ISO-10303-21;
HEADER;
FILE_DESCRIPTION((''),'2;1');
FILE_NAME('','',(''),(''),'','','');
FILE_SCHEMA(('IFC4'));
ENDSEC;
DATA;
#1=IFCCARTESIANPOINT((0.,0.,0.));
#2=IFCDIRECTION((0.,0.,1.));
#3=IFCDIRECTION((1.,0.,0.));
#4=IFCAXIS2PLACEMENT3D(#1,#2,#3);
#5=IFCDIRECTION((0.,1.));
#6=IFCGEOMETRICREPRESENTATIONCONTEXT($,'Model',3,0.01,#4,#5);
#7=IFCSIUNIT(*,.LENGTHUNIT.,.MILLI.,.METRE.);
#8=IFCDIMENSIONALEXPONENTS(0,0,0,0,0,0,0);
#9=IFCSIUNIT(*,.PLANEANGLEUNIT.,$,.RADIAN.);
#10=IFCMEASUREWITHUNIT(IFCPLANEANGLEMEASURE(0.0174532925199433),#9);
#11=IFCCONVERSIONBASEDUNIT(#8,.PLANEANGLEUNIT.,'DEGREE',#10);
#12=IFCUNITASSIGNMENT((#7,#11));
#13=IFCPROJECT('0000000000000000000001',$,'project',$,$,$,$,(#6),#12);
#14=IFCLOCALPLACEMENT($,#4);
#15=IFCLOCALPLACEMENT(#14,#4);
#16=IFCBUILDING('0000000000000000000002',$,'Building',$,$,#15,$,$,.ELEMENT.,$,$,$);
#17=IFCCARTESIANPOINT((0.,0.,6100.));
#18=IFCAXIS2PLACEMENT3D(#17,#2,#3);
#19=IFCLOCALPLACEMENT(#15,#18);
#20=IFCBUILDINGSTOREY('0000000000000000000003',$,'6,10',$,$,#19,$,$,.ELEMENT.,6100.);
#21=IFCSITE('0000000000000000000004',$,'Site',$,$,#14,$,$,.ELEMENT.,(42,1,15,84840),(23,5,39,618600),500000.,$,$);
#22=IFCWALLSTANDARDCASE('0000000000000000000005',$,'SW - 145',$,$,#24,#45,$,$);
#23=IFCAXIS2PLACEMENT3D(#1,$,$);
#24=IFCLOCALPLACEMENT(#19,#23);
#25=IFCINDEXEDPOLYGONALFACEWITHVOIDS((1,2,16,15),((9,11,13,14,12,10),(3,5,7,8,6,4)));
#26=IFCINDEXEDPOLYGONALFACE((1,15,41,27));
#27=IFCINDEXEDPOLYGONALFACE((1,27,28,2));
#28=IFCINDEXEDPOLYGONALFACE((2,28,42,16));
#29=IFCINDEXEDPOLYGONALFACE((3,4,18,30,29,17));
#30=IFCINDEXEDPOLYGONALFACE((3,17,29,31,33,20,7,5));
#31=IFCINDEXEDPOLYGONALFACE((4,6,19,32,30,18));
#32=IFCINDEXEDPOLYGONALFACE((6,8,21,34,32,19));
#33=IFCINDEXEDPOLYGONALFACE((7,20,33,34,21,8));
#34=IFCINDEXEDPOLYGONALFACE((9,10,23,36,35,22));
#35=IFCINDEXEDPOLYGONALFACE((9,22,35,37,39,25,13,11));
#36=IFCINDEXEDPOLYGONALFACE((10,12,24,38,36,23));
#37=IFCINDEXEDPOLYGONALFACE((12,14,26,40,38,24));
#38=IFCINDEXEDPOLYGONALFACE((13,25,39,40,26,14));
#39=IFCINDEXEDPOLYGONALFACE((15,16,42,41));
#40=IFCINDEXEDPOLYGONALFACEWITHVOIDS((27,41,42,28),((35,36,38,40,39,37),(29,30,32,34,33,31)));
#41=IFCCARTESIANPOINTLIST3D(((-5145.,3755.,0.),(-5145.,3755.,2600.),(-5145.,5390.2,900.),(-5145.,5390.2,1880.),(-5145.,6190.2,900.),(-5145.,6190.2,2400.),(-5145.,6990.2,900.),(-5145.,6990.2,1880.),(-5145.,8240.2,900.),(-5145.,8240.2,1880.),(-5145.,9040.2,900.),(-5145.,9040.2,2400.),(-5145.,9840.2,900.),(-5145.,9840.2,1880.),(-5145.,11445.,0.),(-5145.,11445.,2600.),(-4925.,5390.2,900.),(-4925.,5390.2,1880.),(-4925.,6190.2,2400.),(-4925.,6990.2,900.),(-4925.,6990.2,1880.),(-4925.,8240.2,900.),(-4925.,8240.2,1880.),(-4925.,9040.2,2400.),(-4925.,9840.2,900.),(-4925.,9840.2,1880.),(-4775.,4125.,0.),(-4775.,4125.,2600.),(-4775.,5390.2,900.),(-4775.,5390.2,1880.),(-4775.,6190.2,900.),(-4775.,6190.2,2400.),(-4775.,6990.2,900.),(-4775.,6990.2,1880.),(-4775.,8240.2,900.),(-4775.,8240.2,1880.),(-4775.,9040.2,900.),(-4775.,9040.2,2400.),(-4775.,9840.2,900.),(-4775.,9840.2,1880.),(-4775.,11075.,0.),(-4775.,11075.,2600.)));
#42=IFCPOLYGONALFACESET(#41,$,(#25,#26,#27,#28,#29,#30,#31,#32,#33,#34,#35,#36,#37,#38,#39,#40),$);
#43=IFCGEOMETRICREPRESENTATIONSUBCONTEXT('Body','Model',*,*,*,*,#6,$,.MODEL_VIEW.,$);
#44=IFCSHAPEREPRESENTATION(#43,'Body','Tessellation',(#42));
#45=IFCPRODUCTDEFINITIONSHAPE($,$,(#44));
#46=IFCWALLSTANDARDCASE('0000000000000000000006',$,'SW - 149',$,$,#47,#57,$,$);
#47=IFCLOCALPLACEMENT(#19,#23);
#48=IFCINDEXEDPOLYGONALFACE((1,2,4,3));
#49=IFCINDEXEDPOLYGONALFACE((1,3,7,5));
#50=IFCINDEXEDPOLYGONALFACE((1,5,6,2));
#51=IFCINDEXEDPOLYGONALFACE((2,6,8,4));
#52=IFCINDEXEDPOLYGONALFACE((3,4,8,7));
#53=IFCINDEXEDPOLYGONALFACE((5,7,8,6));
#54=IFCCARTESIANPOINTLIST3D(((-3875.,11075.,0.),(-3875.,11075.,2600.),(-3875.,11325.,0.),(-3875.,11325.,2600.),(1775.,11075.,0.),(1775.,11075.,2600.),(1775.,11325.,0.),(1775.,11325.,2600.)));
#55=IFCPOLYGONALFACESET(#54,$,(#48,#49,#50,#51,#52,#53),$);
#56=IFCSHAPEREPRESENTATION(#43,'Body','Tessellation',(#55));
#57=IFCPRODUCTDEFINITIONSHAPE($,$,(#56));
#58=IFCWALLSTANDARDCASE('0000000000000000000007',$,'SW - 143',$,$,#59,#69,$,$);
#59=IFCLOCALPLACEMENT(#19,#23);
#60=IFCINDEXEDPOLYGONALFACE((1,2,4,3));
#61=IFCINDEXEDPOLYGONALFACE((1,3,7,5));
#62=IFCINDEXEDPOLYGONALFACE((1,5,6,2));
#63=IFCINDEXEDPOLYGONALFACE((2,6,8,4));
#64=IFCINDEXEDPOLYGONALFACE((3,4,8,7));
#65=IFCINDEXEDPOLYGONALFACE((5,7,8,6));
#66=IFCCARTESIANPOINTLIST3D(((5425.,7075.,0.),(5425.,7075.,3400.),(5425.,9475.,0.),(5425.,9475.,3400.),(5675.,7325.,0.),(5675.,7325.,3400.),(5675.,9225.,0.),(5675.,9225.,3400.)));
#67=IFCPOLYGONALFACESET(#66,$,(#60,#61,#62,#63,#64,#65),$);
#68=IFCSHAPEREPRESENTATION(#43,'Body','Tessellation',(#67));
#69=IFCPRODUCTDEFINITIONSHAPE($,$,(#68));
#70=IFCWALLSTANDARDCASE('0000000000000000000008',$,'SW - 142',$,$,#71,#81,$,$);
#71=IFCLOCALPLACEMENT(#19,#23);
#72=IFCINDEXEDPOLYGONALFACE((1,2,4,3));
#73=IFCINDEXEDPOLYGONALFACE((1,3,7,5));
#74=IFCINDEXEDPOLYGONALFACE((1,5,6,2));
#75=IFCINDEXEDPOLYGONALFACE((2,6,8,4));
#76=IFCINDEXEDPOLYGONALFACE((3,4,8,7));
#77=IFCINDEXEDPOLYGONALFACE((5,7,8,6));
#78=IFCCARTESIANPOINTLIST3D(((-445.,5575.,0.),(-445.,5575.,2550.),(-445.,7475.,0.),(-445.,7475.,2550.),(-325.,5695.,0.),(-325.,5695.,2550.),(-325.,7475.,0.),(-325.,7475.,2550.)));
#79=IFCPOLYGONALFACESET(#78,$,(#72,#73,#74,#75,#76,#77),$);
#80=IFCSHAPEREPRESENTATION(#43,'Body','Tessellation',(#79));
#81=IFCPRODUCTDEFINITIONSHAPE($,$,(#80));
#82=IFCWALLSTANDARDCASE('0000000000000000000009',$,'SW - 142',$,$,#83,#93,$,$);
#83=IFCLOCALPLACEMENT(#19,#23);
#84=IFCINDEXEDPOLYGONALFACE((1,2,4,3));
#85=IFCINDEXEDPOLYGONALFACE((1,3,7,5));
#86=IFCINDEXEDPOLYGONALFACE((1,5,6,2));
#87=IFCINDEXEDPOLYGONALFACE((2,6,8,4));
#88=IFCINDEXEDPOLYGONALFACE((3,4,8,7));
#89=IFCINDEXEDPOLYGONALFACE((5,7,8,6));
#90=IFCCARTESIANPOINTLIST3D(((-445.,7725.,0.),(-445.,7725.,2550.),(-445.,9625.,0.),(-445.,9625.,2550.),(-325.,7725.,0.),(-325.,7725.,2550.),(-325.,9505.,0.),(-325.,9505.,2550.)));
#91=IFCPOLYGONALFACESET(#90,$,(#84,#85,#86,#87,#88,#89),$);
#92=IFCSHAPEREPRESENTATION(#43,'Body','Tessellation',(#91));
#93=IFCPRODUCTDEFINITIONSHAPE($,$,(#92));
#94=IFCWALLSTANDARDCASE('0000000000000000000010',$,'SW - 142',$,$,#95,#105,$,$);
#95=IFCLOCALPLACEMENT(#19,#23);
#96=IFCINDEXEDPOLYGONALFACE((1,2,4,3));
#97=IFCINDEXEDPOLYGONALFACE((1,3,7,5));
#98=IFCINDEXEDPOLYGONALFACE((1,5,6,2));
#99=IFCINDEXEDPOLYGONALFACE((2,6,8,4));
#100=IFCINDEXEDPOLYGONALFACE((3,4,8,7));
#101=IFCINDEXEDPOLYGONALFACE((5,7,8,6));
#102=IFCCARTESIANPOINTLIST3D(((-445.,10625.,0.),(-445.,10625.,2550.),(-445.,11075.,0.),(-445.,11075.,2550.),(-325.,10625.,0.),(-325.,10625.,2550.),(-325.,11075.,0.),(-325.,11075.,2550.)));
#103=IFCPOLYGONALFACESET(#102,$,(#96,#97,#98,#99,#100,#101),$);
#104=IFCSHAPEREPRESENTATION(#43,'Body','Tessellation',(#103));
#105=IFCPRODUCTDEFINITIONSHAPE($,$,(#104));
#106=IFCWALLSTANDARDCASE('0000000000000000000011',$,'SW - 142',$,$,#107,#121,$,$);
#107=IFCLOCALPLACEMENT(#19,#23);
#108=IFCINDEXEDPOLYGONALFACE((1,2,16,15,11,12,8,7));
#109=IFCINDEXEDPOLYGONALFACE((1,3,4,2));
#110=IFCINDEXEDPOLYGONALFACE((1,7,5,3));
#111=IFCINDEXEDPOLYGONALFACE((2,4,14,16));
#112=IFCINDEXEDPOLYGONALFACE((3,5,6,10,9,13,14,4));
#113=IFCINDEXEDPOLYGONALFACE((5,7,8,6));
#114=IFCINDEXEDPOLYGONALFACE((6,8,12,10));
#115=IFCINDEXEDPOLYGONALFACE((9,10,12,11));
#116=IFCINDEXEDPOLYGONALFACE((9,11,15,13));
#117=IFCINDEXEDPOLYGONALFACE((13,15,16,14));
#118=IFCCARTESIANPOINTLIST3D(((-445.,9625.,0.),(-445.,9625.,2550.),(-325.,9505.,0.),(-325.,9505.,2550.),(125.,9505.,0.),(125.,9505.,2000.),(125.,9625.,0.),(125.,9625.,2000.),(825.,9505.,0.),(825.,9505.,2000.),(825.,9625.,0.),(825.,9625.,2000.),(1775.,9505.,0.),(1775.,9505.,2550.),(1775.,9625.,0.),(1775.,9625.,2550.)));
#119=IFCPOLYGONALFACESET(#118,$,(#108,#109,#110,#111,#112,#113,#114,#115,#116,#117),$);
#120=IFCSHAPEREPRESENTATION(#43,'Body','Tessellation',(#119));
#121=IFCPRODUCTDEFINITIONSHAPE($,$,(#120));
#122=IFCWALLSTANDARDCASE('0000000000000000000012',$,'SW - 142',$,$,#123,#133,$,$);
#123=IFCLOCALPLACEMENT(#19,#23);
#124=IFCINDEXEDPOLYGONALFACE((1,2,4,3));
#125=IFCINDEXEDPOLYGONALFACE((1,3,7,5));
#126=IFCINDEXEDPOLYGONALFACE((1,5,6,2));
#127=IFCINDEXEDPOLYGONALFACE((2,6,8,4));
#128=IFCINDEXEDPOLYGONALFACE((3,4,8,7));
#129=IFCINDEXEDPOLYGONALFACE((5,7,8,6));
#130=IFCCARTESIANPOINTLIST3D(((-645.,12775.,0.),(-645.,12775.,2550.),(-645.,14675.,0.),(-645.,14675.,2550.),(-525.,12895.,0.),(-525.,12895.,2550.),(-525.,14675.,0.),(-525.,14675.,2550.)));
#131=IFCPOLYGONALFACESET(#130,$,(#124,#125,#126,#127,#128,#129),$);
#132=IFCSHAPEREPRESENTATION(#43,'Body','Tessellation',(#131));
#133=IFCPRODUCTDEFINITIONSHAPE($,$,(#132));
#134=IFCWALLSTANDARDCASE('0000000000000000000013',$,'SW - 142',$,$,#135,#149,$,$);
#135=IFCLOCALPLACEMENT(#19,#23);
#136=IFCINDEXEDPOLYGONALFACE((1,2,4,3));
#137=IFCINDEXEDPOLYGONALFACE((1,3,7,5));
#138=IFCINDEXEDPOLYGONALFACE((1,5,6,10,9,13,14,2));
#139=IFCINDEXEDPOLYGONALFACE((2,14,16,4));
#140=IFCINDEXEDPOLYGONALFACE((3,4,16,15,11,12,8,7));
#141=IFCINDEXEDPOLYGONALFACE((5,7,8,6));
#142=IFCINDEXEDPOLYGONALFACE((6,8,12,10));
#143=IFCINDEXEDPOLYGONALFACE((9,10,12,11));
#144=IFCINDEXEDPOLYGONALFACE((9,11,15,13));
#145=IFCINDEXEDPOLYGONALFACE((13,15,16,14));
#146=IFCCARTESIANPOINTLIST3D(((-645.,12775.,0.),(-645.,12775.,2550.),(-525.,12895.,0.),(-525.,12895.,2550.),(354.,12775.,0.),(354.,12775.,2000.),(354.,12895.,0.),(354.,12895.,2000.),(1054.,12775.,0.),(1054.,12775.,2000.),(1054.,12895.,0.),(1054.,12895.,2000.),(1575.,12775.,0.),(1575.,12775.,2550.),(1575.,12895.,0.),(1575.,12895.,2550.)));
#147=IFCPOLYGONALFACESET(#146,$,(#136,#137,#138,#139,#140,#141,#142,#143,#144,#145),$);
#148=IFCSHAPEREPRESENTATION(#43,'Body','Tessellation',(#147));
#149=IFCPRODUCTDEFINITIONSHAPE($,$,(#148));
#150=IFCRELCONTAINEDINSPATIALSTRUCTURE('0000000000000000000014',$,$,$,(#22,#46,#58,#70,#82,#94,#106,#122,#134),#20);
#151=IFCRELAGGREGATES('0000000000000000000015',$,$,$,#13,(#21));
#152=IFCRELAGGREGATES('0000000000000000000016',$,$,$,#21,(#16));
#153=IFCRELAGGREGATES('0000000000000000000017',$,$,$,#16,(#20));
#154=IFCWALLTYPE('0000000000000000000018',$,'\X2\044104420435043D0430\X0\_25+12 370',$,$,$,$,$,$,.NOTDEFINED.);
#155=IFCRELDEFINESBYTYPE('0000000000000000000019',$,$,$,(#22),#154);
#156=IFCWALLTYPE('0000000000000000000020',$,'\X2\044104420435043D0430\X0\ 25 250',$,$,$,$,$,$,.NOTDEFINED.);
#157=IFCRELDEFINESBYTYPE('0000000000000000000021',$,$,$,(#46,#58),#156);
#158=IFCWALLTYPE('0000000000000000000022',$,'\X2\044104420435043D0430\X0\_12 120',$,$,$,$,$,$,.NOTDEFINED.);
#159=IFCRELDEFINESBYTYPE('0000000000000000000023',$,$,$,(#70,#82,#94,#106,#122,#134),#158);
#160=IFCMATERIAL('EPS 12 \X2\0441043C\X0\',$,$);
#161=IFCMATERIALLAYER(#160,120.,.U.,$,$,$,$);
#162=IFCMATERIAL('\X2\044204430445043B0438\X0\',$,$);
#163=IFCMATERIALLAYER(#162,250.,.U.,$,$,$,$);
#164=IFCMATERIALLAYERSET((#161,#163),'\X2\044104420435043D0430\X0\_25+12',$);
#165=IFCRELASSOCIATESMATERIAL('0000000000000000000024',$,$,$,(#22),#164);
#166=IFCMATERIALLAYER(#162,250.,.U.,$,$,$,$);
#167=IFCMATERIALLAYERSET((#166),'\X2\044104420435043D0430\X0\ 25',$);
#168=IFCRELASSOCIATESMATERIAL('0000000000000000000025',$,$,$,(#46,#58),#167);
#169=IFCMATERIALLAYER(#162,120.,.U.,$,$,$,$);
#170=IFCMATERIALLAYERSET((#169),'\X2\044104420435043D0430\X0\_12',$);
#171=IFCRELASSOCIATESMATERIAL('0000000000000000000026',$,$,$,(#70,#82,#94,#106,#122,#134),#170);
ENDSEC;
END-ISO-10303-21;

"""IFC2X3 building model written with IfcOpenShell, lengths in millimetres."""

from ifc_helpers import new_model, entity, si_unit, converted_unit, direction, frame, origin_with_axes, origin_2d_with_axis, place, context, subcontext, project, spatial, polyline, rectangle, outline, extrude, material, layer, layer_set, layer_usage, type_object, element, save


model = new_model("IFC2X3")

# Units and contexts
model_context = context("Model", 3, precision=0.01, world=origin_with_axes(), true_north=direction((0.0, 1.0)))
body_context = subcontext(model_context, "Body", "Model", "MODEL_VIEW")
ifc_project = project(units=[si_unit("LENGTHUNIT", "METRE", prefix="MILLI"), converted_unit("PLANEANGLEUNIT", "DEGREE", entity("IfcPlaneAngleMeasure", 0.0174532925199433), si_unit("PLANEANGLEUNIT", "RADIAN"), dimensions=[0, 0, 0, 0, 0, 0, 0])], contexts=[model_context])

# Site, building, storey
site_placement = place(None, origin_with_axes())
site = spatial("IfcSite", under=ifc_project, at=site_placement, Name="Site", CompositionType="ELEMENT", RefLatitude=(42, 1, 15, 84840), RefLongitude=(23, 5, 39, 618600), RefElevation=500000.0)
building_placement = place(site_placement, origin_with_axes())
building = spatial("IfcBuilding", under=site, at=building_placement, Name="Building", CompositionType="ELEMENT")
storey_placement = place(building_placement, frame((0.0, 0.0, 6100.0), z_axis=(0.0, 0.0, 1.0), x_axis=(1.0, 0.0, 0.0)))
storey = spatial("IfcBuildingStorey", under=building, at=storey_placement, Name="6,10", CompositionType="ELEMENT", Elevation=6100.0)

# Shared definitions
ifc_material_1 = material(Name="EPS 12 см")
ifc_layer_1 = layer(ifc_material_1, 120.0, ventilated="UNKNOWN")
ifc_material_2 = material(Name="тухли")
ifc_layer_2 = layer(ifc_material_2, 250.0, ventilated="UNKNOWN")
ifc_layer_set_1 = layer_set([ifc_layer_1, ifc_layer_2], Name="стена_25+12")
wall_type_1 = type_object("IfcWallType", Name="стена_25+12 370", PredefinedType="NOTDEFINED")

# Wall, openings
ifc_layer_usage_1 = layer_usage(ifc_layer_set_1, "AXIS2", "POSITIVE", -120.0)
wall_1_placement = place(storey_placement, frame((-5025.0, 11325.0, 0.0), z_axis=(0.0, 0.0, 1.0), x_axis=(0.0, -1.0, 0.0)))
wall_1 = element("IfcWallStandardCase", 1, at=wall_1_placement, inside=storey, type_object=wall_type_1, material=ifc_layer_usage_1, Name="SW - 145", context=body_context, shape_type="SweptSolid", body=[
    extrude(outline(polyline([(-120.0, -120.0), (7570.0, -120.0), (7200.0, 250.0), (250.0, 250.0), (-120.0, -120.0)])), origin_with_axes(), (0.0, 0.0, 1.0), 2600.0),
])
opening_1_placement = place(wall_1_placement, frame((5534.8, 0.0, 900.0), z_axis=(0.0, 0.0, 1.0), x_axis=(1.0, 0.0, 0.0)))
element("IfcOpeningElement", 2, at=opening_1_placement, cuts=wall_1, context=body_context, shape_type="SweptSolid", body=[
    extrude(outline(polyline([(-400.0, 0.0), (-400.0, -1500.0), (400.0, -980.0), (400.0, 0.0), (-400.0, 0.0)])), frame((0.0, 100.0, 0.0), z_axis=(0.0, 1.0, 0.0), x_axis=(1.0, 0.0, 0.0)), (0.0, 0.0, -1.0), 590.0),
    extrude(outline(polyline([(400.0, 0.0), (400.0, 980.0), (-400.0, 1500.0), (-400.0, 0.0), (400.0, 0.0)])), frame((0.0, 100.0, 0.0), z_axis=(0.0, -1.0, 0.0), x_axis=(1.0, 0.0, 0.0)), (0.0, 0.0, -1.0), 520.0),
])
opening_2_placement = place(wall_1_placement, frame((1884.8, 0.0, 900.0), z_axis=(0.0, 0.0, 1.0), x_axis=(1.0, 0.0, 0.0)))
element("IfcOpeningElement", 3, at=opening_2_placement, cuts=wall_1, context=body_context, shape_type="SweptSolid", body=[
    extrude(outline(polyline([(-400.0, 0.0), (-400.0, -1500.0), (400.0, -980.0), (400.0, 0.0), (-400.0, 0.0)])), frame((0.0, 100.0, 0.0), z_axis=(0.0, -1.0, 0.0), x_axis=(-1.0, 0.0, 0.0)), (0.0, 0.0, 1.0), 590.0),
    extrude(outline(polyline([(400.0, 0.0), (400.0, 980.0), (-400.0, 1500.0), (-400.0, 0.0), (400.0, 0.0)])), frame((0.0, 100.0, 0.0), z_axis=(0.0, 1.0, 0.0), x_axis=(-1.0, 0.0, 0.0)), (0.0, 0.0, 1.0), 520.0),
])
opening_3_placement = place(wall_1_placement, frame((4734.8, 0.0, 900.0), z_axis=(0.0, 0.0, 1.0), x_axis=(1.0, 0.0, 0.0)))
element("IfcOpeningElement", 4, at=opening_3_placement, cuts=wall_1, context=body_context, shape_type="SweptSolid", body=[
    extrude(outline(polyline([(-400.0, 0.0), (-400.0, -1500.0), (400.0, -980.0), (400.0, 0.0), (-400.0, 0.0)])), frame((0.0, 100.0, 0.0), z_axis=(0.0, -1.0, 0.0), x_axis=(-1.0, 0.0, 0.0)), (0.0, 0.0, 1.0), 590.0),
    extrude(outline(polyline([(400.0, 0.0), (400.0, 980.0), (-400.0, 1500.0), (-400.0, 0.0), (400.0, 0.0)])), frame((0.0, 100.0, 0.0), z_axis=(0.0, 1.0, 0.0), x_axis=(-1.0, 0.0, 0.0)), (0.0, 0.0, 1.0), 520.0),
])
opening_4_placement = place(wall_1_placement, frame((2684.8, 0.0, 900.0), z_axis=(0.0, 0.0, 1.0), x_axis=(1.0, 0.0, 0.0)))
element("IfcOpeningElement", 5, at=opening_4_placement, cuts=wall_1, context=body_context, shape_type="SweptSolid", body=[
    extrude(outline(polyline([(-400.0, 0.0), (-400.0, -1500.0), (400.0, -980.0), (400.0, 0.0), (-400.0, 0.0)])), frame((0.0, 100.0, 0.0), z_axis=(0.0, 1.0, 0.0), x_axis=(1.0, 0.0, 0.0)), (0.0, 0.0, -1.0), 590.0),
    extrude(outline(polyline([(400.0, 0.0), (400.0, 980.0), (-400.0, 1500.0), (-400.0, 0.0), (400.0, 0.0)])), frame((0.0, 100.0, 0.0), z_axis=(0.0, -1.0, 0.0), x_axis=(1.0, 0.0, 0.0)), (0.0, 0.0, -1.0), 520.0),
])

# Walls
ifc_layer_3 = layer(ifc_material_2, 250.0, ventilated="UNKNOWN")
ifc_layer_set_2 = layer_set([ifc_layer_3], Name="стена 25")
wall_type_2 = type_object("IfcWallType", Name="стена 25 250", PredefinedType="NOTDEFINED")
ifc_layer_usage_2 = layer_usage(ifc_layer_set_2, "AXIS2", "NEGATIVE", 0.0)
wall_2_placement = place(storey_placement, frame((-3875.0, 11325.0, 0.0), z_axis=(0.0, 0.0, 1.0), x_axis=(1.0, 0.0, 0.0)))
element("IfcWallStandardCase", 6, at=wall_2_placement, inside=storey, type_object=wall_type_2, material=ifc_layer_usage_2, Name="SW - 149", context=body_context, shape_type="SweptSolid", body=[
    extrude(outline(polyline([(0.0, -250.0), (5650.0, -250.0), (5650.0, 0.0), (0.0, 0.0), (0.0, -250.0)])), origin_with_axes(), (0.0, 0.0, 1.0), 2600.0),
])
ifc_layer_usage_3 = layer_usage(ifc_layer_set_2, "AXIS2", "POSITIVE", 0.0)
wall_3_placement = place(storey_placement, frame((5425.0, 9475.0, 0.0), z_axis=(0.0, 0.0, 1.0), x_axis=(0.0, -1.0, 0.0)))
element("IfcWallStandardCase", 7, at=wall_3_placement, inside=storey, type_object=wall_type_2, material=ifc_layer_usage_3, Name="SW - 143", context=body_context, shape_type="SweptSolid", body=[
    extrude(outline(polyline([(0.0, 0.0), (2400.0, 0.0), (2150.0, 250.0), (250.0, 250.0), (0.0, 0.0)])), origin_with_axes(), (0.0, 0.0, 1.0), 3400.0),
])
ifc_layer_4 = layer(ifc_material_2, 120.0, ventilated="UNKNOWN")
ifc_layer_set_3 = layer_set([ifc_layer_4], Name="стена_12")
ifc_layer_usage_4 = layer_usage(ifc_layer_set_3, "AXIS2", "NEGATIVE", 60.0)
wall_type_3 = type_object("IfcWallType", Name="стена_12 120", PredefinedType="NOTDEFINED")
wall_4_placement = place(storey_placement, frame((-385.0, 7475.0, 0.0), z_axis=(0.0, 0.0, 1.0), x_axis=(0.0, -1.0, 0.0)))
element("IfcWallStandardCase", 8, at=wall_4_placement, inside=storey, type_object=wall_type_3, material=ifc_layer_usage_4, Name="SW - 142", context=body_context, shape_type="SweptSolid", body=[
    extrude(outline(polyline([(0.0, -60.0), (1900.0, -60.0), (1780.0, 60.0), (0.0, 60.0), (0.0, -60.0)])), origin_with_axes(), (0.0, 0.0, 1.0), 2550.0),
])
ifc_layer_usage_5 = layer_usage(ifc_layer_set_3, "AXIS2", "POSITIVE", -60.0)
wall_5_placement = place(storey_placement, frame((-385.0, 7725.0, 0.0), z_axis=(0.0, 0.0, 1.0), x_axis=(0.0, 1.0, 0.0)))
element("IfcWallStandardCase", 9, at=wall_5_placement, inside=storey, type_object=wall_type_3, material=ifc_layer_usage_5, Name="SW - 142", context=body_context, shape_type="SweptSolid", body=[
    extrude(outline(polyline([(0.0, -60.0), (1780.0, -60.0), (1900.0, 60.0), (0.0, 60.0), (0.0, -60.0)])), origin_with_axes(), (0.0, 0.0, 1.0), 2550.0),
])
ifc_layer_usage_6 = layer_usage(ifc_layer_set_3, "AXIS2", "POSITIVE", -60.0)
wall_6_placement = place(storey_placement, frame((-385.0, 10625.0, 0.0), z_axis=(0.0, 0.0, 1.0), x_axis=(0.0, 1.0, 0.0)))
element("IfcWallStandardCase", 10, at=wall_6_placement, inside=storey, type_object=wall_type_3, material=ifc_layer_usage_6, Name="SW - 142", context=body_context, shape_type="SweptSolid", body=[
    extrude(outline(polyline([(0.0, -60.0), (450.0, -60.0), (450.0, 60.0), (0.0, 60.0), (0.0, -60.0)])), origin_with_axes(), (0.0, 0.0, 1.0), 2550.0),
])

# Wall, opening
ifc_layer_usage_7 = layer_usage(ifc_layer_set_3, "AXIS2", "POSITIVE", -60.0)
wall_7_placement = place(storey_placement, frame((1775.0, 9565.0, 0.0), z_axis=(0.0, 0.0, 1.0), x_axis=(-1.0, 0.0, 0.0)))
wall_7 = element("IfcWallStandardCase", 11, at=wall_7_placement, inside=storey, type_object=wall_type_3, material=ifc_layer_usage_7, Name="SW - 142", context=body_context, shape_type="SweptSolid", body=[
    extrude(outline(polyline([(0.0, -60.0), (2220.0, -60.0), (2100.0, 60.0), (0.0, 60.0), (0.0, -60.0)])), origin_with_axes(), (0.0, 0.0, 1.0), 2550.0),
])
opening_5_placement = place(wall_7_placement, frame((1300.0, 0.0, 0.0), z_axis=(0.0, 0.0, 1.0), x_axis=(1.0, 0.0, 0.0)))
element("IfcOpeningElement", 12, at=opening_5_placement, cuts=wall_7, context=body_context, shape_type="SweptSolid", body=[
    extrude(rectangle(XDim=700.0, YDim=2000.0, at=origin_2d_with_axis()), frame((0.0, -120.0, 1000.0), z_axis=(0.0, -1.0, 0.0), x_axis=(-1.0, 0.0, 0.0)), (0.0, 0.0, -1.0), 360.0),
])

# Wall
ifc_layer_usage_8 = layer_usage(ifc_layer_set_3, "AXIS2", "NEGATIVE", 60.0)
wall_8_placement = place(storey_placement, frame((-585.0, 14675.0, 0.0), z_axis=(0.0, 0.0, 1.0), x_axis=(0.0, -1.0, 0.0)))
element("IfcWallStandardCase", 13, at=wall_8_placement, inside=storey, type_object=wall_type_3, material=ifc_layer_usage_8, Name="SW - 142", context=body_context, shape_type="SweptSolid", body=[
    extrude(outline(polyline([(0.0, -60.0), (1900.0, -60.0), (1780.0, 60.0), (0.0, 60.0), (0.0, -60.0)])), origin_with_axes(), (0.0, 0.0, 1.0), 2550.0),
])

# Wall, opening
ifc_layer_usage_9 = layer_usage(ifc_layer_set_3, "AXIS2", "NEGATIVE", 60.0)
wall_9_placement = place(storey_placement, frame((1575.0, 12835.0, 0.0), z_axis=(0.0, 0.0, 1.0), x_axis=(-1.0, 0.0, 0.0)))
wall_9 = element("IfcWallStandardCase", 14, at=wall_9_placement, inside=storey, type_object=wall_type_3, material=ifc_layer_usage_9, Name="SW - 142", context=body_context, shape_type="SweptSolid", body=[
    extrude(outline(polyline([(0.0, -60.0), (2100.0, -60.0), (2220.0, 60.0), (0.0, 60.0), (0.0, -60.0)])), origin_with_axes(), (0.0, 0.0, 1.0), 2550.0),
])
opening_6_placement = place(wall_9_placement, frame((871.0, 0.0, 0.0), z_axis=(0.0, 0.0, 1.0), x_axis=(1.0, 0.0, 0.0)))
element("IfcOpeningElement", 15, at=opening_6_placement, cuts=wall_9, context=body_context, shape_type="SweptSolid", body=[
    extrude(rectangle(XDim=700.0, YDim=2000.0, at=origin_2d_with_axis()), frame((0.0, 120.0, 1000.0), z_axis=(0.0, 1.0, 0.0), x_axis=(1.0, 0.0, 0.0)), (0.0, 0.0, -1.0), 360.0),
])

save(model, "model.ifc")
